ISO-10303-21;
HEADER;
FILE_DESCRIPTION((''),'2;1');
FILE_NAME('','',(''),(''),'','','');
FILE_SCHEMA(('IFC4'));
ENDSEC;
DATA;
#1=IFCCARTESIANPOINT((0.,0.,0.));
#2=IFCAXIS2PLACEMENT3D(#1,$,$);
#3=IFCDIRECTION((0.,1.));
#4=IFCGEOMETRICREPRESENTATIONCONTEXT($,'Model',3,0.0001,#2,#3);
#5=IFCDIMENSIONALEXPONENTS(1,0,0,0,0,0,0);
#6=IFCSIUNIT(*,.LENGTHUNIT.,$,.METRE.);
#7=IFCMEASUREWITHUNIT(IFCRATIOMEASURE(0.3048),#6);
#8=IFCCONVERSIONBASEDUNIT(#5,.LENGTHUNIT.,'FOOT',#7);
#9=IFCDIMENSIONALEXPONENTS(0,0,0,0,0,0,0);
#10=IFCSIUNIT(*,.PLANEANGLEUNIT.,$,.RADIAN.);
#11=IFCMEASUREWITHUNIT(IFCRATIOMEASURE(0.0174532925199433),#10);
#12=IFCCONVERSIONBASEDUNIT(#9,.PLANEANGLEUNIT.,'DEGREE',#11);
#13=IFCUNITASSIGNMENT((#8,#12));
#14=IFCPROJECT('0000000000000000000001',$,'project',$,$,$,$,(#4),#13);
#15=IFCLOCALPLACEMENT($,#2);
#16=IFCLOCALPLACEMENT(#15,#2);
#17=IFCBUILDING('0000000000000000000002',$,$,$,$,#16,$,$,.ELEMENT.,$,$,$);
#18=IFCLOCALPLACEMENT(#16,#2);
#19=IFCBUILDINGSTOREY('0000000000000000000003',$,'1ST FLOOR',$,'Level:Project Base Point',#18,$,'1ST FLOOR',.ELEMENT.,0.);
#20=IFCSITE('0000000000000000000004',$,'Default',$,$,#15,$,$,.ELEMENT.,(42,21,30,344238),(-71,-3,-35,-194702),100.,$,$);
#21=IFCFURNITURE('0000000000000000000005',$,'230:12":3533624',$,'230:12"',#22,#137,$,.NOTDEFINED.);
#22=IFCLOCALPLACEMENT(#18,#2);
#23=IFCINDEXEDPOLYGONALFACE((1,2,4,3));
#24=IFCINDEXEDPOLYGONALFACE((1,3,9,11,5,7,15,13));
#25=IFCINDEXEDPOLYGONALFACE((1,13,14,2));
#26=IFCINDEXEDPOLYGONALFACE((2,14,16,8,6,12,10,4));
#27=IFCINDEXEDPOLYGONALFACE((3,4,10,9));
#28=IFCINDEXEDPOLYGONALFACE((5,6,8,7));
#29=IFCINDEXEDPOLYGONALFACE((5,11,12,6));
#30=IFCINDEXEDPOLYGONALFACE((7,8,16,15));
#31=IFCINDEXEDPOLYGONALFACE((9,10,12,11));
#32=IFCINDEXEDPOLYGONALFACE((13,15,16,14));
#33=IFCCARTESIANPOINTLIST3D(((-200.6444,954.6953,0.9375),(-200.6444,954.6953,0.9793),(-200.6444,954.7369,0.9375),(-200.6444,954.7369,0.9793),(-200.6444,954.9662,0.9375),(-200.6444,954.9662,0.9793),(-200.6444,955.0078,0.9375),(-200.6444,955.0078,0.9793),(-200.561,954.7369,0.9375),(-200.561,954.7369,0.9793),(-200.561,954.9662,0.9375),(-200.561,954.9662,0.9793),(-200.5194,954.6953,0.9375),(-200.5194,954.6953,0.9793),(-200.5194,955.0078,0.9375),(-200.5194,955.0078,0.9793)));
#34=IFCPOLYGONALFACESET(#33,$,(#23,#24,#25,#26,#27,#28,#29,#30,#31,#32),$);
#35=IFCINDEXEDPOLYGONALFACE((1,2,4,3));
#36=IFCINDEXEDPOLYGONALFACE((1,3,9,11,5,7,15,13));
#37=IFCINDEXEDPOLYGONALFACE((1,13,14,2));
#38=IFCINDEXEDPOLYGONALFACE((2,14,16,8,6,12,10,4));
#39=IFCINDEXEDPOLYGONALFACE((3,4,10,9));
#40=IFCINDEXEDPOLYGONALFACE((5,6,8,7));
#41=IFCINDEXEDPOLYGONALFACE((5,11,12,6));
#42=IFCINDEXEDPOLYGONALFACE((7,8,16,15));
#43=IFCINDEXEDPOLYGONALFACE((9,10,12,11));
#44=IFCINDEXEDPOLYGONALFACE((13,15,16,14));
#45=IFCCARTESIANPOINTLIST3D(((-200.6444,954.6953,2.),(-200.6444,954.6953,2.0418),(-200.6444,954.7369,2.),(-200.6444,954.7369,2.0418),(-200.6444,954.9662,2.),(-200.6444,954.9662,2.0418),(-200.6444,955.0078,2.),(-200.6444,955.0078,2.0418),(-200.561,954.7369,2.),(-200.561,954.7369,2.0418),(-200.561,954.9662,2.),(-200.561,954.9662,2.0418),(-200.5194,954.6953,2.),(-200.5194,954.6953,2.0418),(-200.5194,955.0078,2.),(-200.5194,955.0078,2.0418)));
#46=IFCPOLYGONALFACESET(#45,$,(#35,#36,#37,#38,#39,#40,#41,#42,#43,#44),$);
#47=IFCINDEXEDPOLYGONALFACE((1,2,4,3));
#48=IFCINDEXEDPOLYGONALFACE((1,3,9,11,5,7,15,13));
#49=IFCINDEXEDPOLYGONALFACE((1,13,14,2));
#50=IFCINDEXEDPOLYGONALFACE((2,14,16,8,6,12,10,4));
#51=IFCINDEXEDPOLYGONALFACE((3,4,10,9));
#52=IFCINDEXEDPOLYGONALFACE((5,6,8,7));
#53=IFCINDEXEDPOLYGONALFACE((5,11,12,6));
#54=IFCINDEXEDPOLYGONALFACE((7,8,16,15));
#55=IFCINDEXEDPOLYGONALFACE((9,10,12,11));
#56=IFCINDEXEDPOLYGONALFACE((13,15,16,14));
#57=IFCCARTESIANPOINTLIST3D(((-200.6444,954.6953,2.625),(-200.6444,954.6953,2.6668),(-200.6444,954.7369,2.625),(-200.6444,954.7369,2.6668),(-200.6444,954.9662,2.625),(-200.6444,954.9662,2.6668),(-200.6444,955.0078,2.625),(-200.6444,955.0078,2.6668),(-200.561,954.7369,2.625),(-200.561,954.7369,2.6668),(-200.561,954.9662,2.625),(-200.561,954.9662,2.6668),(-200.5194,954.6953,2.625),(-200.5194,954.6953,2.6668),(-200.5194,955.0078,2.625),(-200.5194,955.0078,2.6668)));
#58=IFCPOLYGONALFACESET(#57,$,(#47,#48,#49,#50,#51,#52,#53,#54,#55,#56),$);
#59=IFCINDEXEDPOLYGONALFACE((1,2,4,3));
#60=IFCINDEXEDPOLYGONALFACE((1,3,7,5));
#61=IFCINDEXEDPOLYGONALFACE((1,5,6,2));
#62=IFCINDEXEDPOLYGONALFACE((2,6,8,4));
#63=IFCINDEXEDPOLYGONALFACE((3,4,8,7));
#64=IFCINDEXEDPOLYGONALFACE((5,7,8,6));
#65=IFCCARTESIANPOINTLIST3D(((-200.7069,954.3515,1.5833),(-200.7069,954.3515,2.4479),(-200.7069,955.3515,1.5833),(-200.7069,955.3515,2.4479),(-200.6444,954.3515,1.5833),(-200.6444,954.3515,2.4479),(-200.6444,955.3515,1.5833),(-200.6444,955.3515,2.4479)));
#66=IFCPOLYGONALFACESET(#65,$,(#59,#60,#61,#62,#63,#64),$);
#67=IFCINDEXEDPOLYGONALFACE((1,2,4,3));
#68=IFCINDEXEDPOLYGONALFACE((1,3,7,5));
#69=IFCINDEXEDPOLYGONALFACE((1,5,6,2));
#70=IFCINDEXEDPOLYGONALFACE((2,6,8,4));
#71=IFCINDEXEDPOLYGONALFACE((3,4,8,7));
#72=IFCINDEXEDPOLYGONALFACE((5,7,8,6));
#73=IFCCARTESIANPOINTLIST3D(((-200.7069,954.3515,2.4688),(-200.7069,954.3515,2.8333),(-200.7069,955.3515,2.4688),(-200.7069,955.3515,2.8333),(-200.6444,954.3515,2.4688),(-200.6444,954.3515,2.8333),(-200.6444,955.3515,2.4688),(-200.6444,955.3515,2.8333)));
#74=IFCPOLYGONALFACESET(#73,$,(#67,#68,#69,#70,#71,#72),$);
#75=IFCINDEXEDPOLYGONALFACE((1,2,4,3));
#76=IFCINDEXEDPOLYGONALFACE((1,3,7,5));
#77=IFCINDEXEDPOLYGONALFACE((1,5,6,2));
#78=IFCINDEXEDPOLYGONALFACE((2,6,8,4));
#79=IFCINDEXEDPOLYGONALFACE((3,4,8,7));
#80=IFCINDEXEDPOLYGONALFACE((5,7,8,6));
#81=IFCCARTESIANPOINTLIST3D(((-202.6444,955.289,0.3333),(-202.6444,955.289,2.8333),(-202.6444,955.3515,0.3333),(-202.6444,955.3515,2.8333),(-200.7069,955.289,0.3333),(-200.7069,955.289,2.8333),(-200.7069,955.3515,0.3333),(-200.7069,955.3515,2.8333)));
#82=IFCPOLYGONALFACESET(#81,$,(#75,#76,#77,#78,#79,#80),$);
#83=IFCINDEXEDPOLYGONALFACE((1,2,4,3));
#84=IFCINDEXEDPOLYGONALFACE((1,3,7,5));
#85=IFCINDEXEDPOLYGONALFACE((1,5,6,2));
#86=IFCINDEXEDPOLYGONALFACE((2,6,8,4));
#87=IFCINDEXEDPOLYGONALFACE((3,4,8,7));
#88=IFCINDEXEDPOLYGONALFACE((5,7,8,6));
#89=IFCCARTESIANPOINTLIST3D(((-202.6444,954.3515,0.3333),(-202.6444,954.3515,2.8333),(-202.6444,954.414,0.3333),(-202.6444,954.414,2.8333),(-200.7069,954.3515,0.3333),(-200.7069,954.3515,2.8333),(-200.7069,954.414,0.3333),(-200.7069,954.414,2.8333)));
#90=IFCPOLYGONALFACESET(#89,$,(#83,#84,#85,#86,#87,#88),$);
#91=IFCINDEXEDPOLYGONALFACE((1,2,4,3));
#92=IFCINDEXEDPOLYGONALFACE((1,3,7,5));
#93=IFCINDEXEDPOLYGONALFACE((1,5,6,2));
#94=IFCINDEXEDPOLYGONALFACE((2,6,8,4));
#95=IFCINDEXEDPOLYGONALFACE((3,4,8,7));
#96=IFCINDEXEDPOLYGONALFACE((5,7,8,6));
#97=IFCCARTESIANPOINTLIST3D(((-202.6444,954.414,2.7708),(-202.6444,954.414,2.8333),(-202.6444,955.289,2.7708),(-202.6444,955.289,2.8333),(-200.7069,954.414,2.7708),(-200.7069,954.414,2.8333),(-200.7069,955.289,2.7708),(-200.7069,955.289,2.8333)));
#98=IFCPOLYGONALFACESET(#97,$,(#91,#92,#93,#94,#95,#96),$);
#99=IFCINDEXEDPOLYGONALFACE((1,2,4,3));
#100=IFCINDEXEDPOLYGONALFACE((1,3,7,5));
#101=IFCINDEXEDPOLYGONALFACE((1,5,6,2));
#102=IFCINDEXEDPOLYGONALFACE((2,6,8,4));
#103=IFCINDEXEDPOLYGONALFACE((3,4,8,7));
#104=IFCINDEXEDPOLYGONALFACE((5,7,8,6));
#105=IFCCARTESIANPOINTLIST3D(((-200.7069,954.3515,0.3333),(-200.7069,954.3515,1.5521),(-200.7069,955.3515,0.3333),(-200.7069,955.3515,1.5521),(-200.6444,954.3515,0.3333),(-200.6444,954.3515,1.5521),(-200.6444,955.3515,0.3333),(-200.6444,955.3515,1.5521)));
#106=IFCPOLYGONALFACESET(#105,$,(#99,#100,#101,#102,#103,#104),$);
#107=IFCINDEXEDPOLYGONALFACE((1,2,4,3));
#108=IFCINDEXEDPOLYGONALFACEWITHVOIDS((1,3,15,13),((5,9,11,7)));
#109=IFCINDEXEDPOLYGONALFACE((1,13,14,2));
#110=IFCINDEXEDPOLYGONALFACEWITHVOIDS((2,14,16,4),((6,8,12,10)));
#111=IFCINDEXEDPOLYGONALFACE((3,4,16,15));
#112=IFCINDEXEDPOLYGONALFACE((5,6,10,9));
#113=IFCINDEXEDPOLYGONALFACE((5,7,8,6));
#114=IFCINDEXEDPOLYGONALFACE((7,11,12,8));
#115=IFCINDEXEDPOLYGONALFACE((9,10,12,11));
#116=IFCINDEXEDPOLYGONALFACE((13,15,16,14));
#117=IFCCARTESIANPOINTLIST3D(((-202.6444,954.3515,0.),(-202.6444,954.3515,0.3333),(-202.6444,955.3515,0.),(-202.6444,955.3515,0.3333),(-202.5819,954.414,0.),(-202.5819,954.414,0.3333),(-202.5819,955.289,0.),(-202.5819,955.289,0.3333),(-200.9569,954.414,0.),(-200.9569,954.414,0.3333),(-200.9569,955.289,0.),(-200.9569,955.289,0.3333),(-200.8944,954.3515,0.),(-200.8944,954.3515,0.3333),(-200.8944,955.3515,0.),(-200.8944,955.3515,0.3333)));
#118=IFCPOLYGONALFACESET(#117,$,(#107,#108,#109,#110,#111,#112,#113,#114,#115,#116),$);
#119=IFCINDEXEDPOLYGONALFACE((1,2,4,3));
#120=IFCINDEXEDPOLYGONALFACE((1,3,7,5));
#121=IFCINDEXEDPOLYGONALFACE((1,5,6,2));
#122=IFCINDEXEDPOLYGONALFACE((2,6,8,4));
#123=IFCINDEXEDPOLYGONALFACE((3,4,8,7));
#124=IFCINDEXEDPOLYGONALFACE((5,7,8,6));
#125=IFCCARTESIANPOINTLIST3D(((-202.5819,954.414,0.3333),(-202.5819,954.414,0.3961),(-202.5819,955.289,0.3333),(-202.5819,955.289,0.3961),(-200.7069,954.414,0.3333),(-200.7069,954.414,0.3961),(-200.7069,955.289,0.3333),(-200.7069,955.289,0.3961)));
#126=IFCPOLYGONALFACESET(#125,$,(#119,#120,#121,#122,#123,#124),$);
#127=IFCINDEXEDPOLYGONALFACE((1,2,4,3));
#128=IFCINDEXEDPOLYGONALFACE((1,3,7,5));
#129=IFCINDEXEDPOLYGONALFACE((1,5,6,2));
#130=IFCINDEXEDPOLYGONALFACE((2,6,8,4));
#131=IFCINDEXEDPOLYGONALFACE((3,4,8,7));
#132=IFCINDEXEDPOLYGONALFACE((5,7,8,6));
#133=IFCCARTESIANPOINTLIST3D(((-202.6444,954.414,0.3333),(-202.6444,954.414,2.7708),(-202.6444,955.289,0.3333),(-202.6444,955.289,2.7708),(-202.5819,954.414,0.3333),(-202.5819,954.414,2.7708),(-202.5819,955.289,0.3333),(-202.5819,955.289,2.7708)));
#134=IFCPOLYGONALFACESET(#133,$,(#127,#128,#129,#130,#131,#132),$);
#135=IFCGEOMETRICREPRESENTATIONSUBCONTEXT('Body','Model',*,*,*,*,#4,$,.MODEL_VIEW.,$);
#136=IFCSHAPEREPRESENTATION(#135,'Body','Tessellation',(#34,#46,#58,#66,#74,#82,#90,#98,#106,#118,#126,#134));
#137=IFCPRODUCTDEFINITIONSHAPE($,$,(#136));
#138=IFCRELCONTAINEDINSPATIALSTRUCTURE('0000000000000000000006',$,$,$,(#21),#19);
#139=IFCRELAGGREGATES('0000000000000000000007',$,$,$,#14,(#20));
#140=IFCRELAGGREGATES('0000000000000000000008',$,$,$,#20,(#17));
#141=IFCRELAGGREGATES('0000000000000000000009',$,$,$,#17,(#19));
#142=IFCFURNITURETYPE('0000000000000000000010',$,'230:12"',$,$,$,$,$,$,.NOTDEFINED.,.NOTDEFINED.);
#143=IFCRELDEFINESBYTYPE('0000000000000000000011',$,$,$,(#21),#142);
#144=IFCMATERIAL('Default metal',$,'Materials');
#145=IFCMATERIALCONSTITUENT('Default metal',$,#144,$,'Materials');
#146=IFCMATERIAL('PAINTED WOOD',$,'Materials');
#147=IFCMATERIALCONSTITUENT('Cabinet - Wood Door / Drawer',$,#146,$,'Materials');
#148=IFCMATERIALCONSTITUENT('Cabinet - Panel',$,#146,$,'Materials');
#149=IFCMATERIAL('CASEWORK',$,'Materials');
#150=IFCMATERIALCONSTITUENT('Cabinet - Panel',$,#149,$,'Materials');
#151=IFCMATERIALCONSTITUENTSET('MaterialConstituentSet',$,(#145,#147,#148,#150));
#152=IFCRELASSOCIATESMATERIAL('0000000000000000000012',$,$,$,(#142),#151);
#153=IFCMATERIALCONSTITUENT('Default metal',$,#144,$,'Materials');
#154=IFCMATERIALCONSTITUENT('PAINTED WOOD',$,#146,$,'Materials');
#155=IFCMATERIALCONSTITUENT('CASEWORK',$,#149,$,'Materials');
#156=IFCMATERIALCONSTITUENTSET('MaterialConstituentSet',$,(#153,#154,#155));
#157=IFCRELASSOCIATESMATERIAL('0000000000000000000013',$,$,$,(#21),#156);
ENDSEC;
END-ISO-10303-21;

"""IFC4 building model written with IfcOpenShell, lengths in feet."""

from ifc_helpers import new_model, entity, si_unit, converted_unit, direction, frame, frame_2d, origin, origin_2d_with_axis, place, context, subcontext, project, spatial, polyline, rectangle, outline, extrude, source, transform, mapped, material, constituent, constituent_set, type_object, type_shapes, element, save


model = new_model("IFC4")

# Units and contexts
model_context = context("Model", 3, precision=0.0001, world=origin(), true_north=direction((0.0, 1.0)))
body_context = subcontext(model_context, "Body", "Model", "MODEL_VIEW")
ifc_project = project(units=[converted_unit("LENGTHUNIT", "FOOT", entity("IfcRatioMeasure", 0.3048), si_unit("LENGTHUNIT", "METRE"), dimensions=[1, 0, 0, 0, 0, 0, 0]), converted_unit("PLANEANGLEUNIT", "DEGREE", entity("IfcRatioMeasure", 0.0174532925199433), si_unit("PLANEANGLEUNIT", "RADIAN"), dimensions=[0, 0, 0, 0, 0, 0, 0])], contexts=[model_context])

# Site, building, storey
site_placement = place(None, origin())
site = spatial("IfcSite", under=ifc_project, at=site_placement, Name="Default", CompositionType="ELEMENT", RefLatitude=(42, 21, 30, 344238), RefLongitude=(-71, -3, -35, -194702), RefElevation=100.0)
building_placement = place(site_placement, origin())
building = spatial("IfcBuilding", under=site, at=building_placement, CompositionType="ELEMENT")
storey_placement = place(building_placement, origin())
storey = spatial("IfcBuildingStorey", under=building, at=storey_placement, Name="1ST FLOOR", ObjectType="Level:Project Base Point", LongName="1ST FLOOR", CompositionType="ELEMENT", Elevation=0.0)

# Shared definitions
ifc_material_1 = material(Name="Default metal", Category="Materials")
ifc_material_2 = material(Name="PAINTED WOOD", Category="Materials")
ifc_material_3 = material(Name="CASEWORK", Category="Materials")

# Furniture
ifc_constituent_1 = constituent(ifc_material_1, Name="Default metal", Category="Materials")
ifc_constituent_2 = constituent(ifc_material_2, Name="PAINTED WOOD", Category="Materials")
ifc_constituent_3 = constituent(ifc_material_3, Name="CASEWORK", Category="Materials")
ifc_constituent_set_1 = constituent_set(constituents=[ifc_constituent_1, ifc_constituent_2, ifc_constituent_3], Name="MaterialConstituentSet")
ifc_constituent_4 = constituent(ifc_material_1, Name="Default metal", Category="Materials")
ifc_constituent_5 = constituent(ifc_material_2, Name="Cabinet - Wood Door / Drawer", Category="Materials")
ifc_constituent_6 = constituent(ifc_material_2, Name="Cabinet - Panel", Category="Materials")
ifc_constituent_7 = constituent(ifc_material_3, Name="Cabinet - Panel", Category="Materials")
ifc_constituent_set_2 = constituent_set(constituents=[ifc_constituent_4, ifc_constituent_5, ifc_constituent_6, ifc_constituent_7], Name="MaterialConstituentSet")
furniture_type_1 = type_object("IfcFurnitureType", Name="230:12\"", AssemblyPlace="NOTDEFINED", PredefinedType="NOTDEFINED", material=ifc_constituent_set_2)
shared_shape_1 = source(origin(), body_context, "Body", "SweptSolid", [
    extrude(outline(polyline([(-0.1562, -0.0521), (-0.1146, -0.0521), (-0.1146, 0.0313), (0.1146, 0.0313), (0.1146, -0.0521), (0.1562, -0.0521), (0.1562, 0.0729), (-0.1562, 0.0729), (-0.1562, -0.0521)])), frame((0.0615, 2.0521, 0.9375)), (0.0, 0.0, 1.0), 0.0418),
    extrude(outline(polyline([(-0.1562, -0.0521), (-0.1146, -0.0521), (-0.1146, 0.0313), (0.1146, 0.0313), (0.1146, -0.0521), (0.1562, -0.0521), (0.1562, 0.0729), (-0.1562, 0.0729), (-0.1562, -0.0521)])), frame((0.0615, 2.0521, 2.0)), (0.0, 0.0, 1.0), 0.0418),
    extrude(outline(polyline([(-0.1562, -0.0521), (-0.1146, -0.0521), (-0.1146, 0.0313), (0.1146, 0.0313), (0.1146, -0.0521), (0.1562, -0.0521), (0.1562, 0.0729), (-0.1562, 0.0729), (-0.1562, -0.0521)])), frame((0.0615, 2.0521, 2.625)), (0.0, 0.0, 1.0), 0.0418),
    extrude(rectangle(XDim=1.0, YDim=0.0625, at=origin_2d_with_axis()), frame((0.0615, 1.9688, 1.5833), z_axis=(0.0, 0.0, 1.0), x_axis=(-1.0, 0.0, 0.0)), (0.0, 0.0, 1.0), 0.8646),
    extrude(rectangle(XDim=1.0, YDim=0.0625, at=origin_2d_with_axis()), frame((0.0615, 1.9688, 2.4688), z_axis=(0.0, 0.0, 1.0), x_axis=(-1.0, 0.0, 0.0)), (0.0, 0.0, 1.0), 0.3646),
    extrude(rectangle(XDim=1.9375, YDim=0.0625, at=frame_2d((0.0, 0.0), x_axis=(1.0, 0.0))), frame((-0.4073, 0.9687, 0.3333), z_axis=(0.0, 0.0, 1.0), x_axis=(0.0, -1.0, 0.0)), (0.0, 0.0, 1.0), 2.5),
    extrude(rectangle(XDim=1.9375, YDim=0.0625, at=frame_2d((0.0, 0.0), x_axis=(1.0, 0.0))), frame((0.5302, 0.9687, 0.3333), z_axis=(0.0, 0.0, 1.0), x_axis=(0.0, -1.0, 0.0)), (0.0, 0.0, 1.0), 2.5),
    extrude(rectangle(XDim=1.9375, YDim=0.875, at=origin_2d_with_axis()), frame((0.0615, 0.9687, 2.7708), z_axis=(0.0, 0.0, 1.0), x_axis=(0.0, 1.0, 0.0)), (0.0, 0.0, 1.0), 0.0625),
    extrude(rectangle(XDim=1.0, YDim=0.0625, at=origin_2d_with_axis()), frame((0.0615, 1.9688, 0.3333), z_axis=(0.0, 0.0, 1.0), x_axis=(-1.0, 0.0, 0.0)), (0.0, 0.0, 1.0), 1.2187),
    extrude(outline(polyline([(-0.875, -0.5), (0.875, -0.5), (0.875, 0.5), (-0.875, 0.5), (-0.875, -0.5)]), holes=[polyline([(-0.8125, -0.4375), (-0.8125, 0.4375), (0.8125, 0.4375), (0.8125, -0.4375), (-0.8125, -0.4375)])]), frame((0.0615, 0.875, 0.0), z_axis=(0.0, 0.0, 1.0), x_axis=(0.0, -1.0, 0.0)), (0.0, 0.0, 1.0), 0.3333),
    extrude(rectangle(XDim=1.875, YDim=0.875, at=origin_2d_with_axis()), frame((0.0615, 1.0, 0.3333), z_axis=(0.0, 0.0, 1.0), x_axis=(0.0, 1.0, 0.0)), (0.0, 0.0, 1.0), 0.0627),
    extrude(rectangle(XDim=0.875, YDim=0.0625, at=origin_2d_with_axis()), frame((0.0615, 0.0312, 0.3333), z_axis=(0.0, 0.0, 1.0), x_axis=(-1.0, 0.0, 0.0)), (0.0, 0.0, 1.0), 2.4375),
])
type_shapes(furniture_type_1, [shared_shape_1])
furniture_1_placement = place(storey_placement, frame((-202.6444, 954.913, 0.0), z_axis=(0.0, 0.0, 1.0), x_axis=(0.0, -1.0, 0.0)))
element("IfcFurniture", 1, at=furniture_1_placement, inside=storey, type_object=furniture_type_1, material=ifc_constituent_set_1, Name="230:12\":3533624", ObjectType="230:12\"", PredefinedType="NOTDEFINED", context=body_context, shape_type="MappedRepresentation", body=[
    mapped(shared_shape_1, transform((0.0, 0.0, 0.0), scale=1.0)),
])

save(model, "model.ifc")
